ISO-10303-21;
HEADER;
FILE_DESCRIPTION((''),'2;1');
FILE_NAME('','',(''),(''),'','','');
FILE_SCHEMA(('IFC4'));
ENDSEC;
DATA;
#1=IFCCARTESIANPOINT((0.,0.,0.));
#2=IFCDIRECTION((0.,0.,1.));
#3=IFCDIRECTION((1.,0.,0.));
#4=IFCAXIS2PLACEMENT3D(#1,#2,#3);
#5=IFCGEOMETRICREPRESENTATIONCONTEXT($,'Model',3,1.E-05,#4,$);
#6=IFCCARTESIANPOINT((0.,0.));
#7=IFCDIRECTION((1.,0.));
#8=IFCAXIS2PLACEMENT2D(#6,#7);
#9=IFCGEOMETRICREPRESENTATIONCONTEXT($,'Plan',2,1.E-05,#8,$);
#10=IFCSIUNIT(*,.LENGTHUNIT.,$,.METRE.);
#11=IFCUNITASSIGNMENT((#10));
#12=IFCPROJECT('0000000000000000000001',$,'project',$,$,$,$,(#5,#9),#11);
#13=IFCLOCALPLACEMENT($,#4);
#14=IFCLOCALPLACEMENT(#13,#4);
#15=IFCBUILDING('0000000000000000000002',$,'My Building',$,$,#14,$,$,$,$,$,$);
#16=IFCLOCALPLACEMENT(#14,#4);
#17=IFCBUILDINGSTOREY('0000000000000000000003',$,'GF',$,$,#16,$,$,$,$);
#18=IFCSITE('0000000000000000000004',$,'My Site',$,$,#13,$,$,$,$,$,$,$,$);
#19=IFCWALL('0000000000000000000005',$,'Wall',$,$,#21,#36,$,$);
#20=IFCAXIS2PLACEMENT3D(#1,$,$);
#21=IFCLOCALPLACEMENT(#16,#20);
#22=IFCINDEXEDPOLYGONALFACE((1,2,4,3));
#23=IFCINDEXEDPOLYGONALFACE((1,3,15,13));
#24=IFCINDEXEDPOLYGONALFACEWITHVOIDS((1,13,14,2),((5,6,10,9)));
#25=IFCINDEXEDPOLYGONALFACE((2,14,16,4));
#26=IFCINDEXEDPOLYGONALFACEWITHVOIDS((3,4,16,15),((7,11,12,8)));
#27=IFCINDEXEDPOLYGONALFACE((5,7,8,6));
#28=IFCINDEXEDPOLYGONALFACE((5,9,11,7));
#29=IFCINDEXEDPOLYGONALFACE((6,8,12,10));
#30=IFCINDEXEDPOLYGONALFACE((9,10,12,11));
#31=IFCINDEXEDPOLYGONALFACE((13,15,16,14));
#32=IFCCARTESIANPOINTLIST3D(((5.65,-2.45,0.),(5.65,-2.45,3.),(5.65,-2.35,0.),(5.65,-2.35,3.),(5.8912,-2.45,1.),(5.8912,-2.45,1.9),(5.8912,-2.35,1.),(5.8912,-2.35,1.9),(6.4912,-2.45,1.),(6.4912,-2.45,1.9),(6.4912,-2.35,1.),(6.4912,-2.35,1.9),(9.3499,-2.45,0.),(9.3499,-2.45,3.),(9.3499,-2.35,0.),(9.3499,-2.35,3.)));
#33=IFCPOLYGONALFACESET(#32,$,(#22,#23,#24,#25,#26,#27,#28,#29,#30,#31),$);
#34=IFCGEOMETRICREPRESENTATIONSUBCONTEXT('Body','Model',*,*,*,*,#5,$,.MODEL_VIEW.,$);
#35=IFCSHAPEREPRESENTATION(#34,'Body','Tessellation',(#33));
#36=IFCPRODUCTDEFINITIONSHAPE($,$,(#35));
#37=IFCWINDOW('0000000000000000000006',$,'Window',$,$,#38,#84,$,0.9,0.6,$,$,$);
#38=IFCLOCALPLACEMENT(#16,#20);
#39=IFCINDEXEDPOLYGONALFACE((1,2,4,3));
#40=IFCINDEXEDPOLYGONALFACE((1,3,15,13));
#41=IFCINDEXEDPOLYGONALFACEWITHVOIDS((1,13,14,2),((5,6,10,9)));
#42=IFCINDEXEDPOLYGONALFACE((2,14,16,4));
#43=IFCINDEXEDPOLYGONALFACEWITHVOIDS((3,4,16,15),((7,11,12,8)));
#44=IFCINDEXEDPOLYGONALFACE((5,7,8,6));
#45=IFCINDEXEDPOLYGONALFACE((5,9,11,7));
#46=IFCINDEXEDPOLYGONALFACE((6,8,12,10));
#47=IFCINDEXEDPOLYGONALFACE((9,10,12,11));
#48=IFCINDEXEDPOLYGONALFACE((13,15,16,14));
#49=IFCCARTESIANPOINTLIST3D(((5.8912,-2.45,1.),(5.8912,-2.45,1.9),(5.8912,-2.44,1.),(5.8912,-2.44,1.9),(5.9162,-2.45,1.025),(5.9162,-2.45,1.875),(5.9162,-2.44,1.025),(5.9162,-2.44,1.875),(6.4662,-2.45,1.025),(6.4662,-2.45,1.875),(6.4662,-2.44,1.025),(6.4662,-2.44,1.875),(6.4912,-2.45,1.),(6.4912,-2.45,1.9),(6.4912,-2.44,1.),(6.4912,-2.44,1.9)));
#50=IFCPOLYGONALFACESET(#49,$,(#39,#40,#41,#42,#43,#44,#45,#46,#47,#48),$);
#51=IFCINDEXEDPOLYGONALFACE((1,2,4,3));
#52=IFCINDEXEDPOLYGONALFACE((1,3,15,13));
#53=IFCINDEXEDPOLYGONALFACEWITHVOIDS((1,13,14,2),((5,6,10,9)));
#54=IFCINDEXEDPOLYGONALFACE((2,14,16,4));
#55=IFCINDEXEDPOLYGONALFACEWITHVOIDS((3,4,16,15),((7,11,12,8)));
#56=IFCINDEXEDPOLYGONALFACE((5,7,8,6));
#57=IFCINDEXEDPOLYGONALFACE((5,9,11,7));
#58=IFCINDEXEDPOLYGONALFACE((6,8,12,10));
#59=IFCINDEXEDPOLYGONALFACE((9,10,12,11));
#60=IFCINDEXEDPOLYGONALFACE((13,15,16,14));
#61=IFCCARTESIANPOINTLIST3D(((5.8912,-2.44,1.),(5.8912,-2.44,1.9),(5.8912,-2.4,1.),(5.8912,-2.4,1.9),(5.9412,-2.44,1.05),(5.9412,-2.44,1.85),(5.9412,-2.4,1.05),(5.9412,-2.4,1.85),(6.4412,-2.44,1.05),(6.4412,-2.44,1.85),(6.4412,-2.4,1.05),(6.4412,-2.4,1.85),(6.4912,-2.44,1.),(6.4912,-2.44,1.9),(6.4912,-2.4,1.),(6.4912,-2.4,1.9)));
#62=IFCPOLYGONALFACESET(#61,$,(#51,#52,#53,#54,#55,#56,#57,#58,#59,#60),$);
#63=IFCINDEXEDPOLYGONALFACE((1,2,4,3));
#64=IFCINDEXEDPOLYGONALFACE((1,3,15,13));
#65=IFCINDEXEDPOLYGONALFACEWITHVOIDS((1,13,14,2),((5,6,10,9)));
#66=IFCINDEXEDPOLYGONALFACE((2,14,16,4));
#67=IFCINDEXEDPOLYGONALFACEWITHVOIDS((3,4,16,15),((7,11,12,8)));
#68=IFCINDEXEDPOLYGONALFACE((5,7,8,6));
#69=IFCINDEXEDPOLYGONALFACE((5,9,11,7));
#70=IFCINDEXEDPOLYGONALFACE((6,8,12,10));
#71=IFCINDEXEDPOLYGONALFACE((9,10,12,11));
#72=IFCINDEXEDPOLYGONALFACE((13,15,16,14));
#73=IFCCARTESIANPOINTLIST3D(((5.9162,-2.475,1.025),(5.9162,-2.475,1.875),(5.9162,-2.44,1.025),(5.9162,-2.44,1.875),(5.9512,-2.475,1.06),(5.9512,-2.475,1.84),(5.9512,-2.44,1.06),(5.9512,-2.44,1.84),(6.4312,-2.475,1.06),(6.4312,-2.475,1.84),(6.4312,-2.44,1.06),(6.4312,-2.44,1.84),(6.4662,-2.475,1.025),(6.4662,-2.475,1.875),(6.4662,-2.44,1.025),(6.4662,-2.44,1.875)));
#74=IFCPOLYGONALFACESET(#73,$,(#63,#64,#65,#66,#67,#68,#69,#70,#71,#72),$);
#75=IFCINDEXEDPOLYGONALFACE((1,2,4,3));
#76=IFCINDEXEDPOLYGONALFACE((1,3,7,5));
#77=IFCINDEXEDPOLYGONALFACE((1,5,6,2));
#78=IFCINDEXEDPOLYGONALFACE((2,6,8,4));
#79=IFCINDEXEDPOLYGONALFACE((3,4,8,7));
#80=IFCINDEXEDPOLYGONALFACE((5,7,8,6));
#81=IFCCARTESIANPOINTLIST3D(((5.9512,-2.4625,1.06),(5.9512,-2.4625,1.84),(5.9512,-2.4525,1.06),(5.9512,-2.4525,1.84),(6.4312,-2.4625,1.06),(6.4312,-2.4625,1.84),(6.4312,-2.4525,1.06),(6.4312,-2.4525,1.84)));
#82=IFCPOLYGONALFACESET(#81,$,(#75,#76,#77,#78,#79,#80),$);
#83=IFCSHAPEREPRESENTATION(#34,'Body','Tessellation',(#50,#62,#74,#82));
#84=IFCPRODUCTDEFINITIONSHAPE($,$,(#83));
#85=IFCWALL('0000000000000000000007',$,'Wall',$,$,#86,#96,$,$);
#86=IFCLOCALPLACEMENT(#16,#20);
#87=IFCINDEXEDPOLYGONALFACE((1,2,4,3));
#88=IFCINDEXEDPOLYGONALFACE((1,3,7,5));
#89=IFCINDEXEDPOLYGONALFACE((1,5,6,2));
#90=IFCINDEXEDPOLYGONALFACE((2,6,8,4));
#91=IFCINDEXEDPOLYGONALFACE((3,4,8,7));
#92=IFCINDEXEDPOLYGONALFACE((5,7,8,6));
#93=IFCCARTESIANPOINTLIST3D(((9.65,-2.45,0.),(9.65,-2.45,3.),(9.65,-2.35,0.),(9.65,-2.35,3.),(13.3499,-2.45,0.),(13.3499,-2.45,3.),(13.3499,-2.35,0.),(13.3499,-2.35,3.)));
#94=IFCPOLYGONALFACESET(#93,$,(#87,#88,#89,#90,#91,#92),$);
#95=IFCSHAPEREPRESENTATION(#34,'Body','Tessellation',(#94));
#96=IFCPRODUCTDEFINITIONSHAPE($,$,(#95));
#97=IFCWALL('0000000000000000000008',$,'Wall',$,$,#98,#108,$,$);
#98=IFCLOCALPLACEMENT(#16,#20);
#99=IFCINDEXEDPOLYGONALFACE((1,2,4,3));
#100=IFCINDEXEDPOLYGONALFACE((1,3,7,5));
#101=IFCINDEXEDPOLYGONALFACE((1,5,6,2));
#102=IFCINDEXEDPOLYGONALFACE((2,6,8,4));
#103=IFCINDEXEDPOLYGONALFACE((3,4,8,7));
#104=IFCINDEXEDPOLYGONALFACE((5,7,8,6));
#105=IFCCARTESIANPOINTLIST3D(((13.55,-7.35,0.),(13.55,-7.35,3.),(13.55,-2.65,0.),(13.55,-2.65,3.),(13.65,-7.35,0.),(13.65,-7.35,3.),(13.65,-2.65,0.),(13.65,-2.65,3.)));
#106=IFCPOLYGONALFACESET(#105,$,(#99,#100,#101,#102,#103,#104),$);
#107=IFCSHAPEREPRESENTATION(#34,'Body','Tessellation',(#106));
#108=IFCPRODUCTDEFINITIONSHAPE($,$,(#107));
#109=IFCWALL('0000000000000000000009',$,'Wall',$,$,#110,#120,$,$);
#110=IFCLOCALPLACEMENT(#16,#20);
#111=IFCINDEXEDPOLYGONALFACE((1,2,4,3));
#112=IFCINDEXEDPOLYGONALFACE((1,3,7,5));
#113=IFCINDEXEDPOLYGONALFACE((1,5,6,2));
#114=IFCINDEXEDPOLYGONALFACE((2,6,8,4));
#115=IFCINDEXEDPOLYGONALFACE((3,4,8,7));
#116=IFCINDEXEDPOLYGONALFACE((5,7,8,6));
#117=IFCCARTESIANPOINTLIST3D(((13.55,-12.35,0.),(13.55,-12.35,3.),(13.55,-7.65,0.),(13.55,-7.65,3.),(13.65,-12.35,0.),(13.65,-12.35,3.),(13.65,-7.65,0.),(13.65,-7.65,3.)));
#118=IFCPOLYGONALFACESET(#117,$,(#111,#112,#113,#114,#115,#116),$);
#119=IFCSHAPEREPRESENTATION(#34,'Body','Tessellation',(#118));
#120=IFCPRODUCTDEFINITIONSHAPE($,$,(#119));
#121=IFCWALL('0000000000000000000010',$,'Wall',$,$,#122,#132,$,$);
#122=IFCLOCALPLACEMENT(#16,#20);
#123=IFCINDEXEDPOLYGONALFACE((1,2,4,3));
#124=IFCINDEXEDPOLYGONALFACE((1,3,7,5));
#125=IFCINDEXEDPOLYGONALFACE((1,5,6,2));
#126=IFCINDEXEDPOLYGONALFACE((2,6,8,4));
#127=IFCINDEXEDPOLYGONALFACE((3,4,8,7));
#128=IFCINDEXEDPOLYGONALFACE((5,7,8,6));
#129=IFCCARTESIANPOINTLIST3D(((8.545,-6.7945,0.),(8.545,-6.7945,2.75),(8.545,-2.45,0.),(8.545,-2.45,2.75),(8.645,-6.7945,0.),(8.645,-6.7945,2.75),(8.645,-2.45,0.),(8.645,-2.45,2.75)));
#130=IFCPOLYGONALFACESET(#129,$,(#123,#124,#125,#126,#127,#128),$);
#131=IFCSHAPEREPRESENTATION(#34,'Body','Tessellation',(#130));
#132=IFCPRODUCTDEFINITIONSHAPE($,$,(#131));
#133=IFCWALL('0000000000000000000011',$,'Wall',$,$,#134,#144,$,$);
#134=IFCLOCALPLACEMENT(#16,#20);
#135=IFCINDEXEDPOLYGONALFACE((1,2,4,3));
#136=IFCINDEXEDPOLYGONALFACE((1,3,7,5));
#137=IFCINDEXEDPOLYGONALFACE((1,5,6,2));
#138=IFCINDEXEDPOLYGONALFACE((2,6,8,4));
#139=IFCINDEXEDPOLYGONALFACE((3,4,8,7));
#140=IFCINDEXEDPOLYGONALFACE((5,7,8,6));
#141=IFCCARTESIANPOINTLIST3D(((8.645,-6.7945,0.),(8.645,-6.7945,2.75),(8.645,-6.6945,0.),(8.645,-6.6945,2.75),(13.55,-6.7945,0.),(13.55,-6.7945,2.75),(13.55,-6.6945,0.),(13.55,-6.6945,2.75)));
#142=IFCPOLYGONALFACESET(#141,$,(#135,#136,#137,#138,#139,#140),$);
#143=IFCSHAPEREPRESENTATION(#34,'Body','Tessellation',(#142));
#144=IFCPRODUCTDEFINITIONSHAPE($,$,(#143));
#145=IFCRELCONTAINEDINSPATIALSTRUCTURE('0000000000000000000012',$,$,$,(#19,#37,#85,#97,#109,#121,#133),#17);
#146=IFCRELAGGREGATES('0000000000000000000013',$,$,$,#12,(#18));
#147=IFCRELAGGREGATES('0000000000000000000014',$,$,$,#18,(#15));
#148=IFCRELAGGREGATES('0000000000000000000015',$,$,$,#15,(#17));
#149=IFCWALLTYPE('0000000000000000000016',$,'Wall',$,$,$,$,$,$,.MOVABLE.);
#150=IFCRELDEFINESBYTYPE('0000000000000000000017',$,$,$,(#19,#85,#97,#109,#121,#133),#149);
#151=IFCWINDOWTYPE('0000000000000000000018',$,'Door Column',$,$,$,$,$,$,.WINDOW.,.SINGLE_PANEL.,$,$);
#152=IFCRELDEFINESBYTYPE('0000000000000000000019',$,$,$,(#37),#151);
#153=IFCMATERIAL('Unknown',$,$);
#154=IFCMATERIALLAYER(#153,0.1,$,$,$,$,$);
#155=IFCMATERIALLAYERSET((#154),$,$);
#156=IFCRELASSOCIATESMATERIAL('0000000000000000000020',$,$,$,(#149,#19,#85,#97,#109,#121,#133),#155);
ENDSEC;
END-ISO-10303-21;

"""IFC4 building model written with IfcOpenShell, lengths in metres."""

from ifc_helpers import new_model, entity, si_unit, frame, origin_with_axes, origin_2d_with_axis, place, context, subcontext, project, spatial, line, indexed_curve, outline, extrude, shape, source, transform, mapped, material, layer, layer_set, layer_usage, type_object, type_shapes, element, fill, save


model = new_model("IFC4")

# Units and contexts
model_context = context("Model", 3, precision=1e-05, world=origin_with_axes())
plan_context = context("Plan", 2, precision=1e-05, world=origin_2d_with_axis())
body_context_1 = subcontext(model_context, "Body", "Model", "MODEL_VIEW")
body_context_2 = subcontext(plan_context, "Body", "Plan", "PLAN_VIEW")
ifc_project = project(units=[si_unit("LENGTHUNIT", "METRE")], contexts=[model_context, plan_context])

# Site, building, storey
site_placement = place(None, origin_with_axes())
site = spatial("IfcSite", under=ifc_project, at=site_placement, Name="My Site")
building_placement = place(site_placement, origin_with_axes())
building = spatial("IfcBuilding", under=site, at=building_placement, Name="My Building")
storey_placement = place(building_placement, origin_with_axes())
storey = spatial("IfcBuildingStorey", under=building, at=storey_placement, Name="GF")

# Shared definitions
ifc_material_1 = material(Name="Unknown")

# Wall, opening, window
ifc_layer_1 = layer(ifc_material_1, 0.1)
ifc_layer_set_1 = layer_set([ifc_layer_1])
ifc_layer_usage_1 = layer_usage(ifc_layer_set_1, "AXIS2", "POSITIVE", 0.0)
wall_type_1 = type_object("IfcWallType", Name="Wall", PredefinedType="MOVABLE", material=ifc_layer_set_1)
wall_1_placement = place(storey_placement, frame((5.65, -2.45, 0.0), z_axis=(0.0, 0.0, 1.0), x_axis=(1.0, 0.0, 0.0)))
wall_1 = element("IfcWall", 1, at=wall_1_placement, inside=storey, type_object=wall_type_1, material=ifc_layer_usage_1, Name="Wall", context=body_context_1, shape_type="SweptSolid", body=[
    extrude(outline(indexed_curve([(0.0, 0.0), (0.0, 0.1), (3.6999, 0.1), (3.6999, 0.0)], segments=[line(1, 2, 3, 4, 1)])), origin_with_axes(), (0.0, 0.0, 1.0), 3.0),
])
shared_shape_1 = source(origin_with_axes(), body_context_1, "Body", "SweptSolid", [
    extrude(outline(indexed_curve([(0.0, 0.0), (0.6, 0.0), (0.6, 0.9), (0.0, 0.9)], segments=[line(1, 2, 3, 4, 1)])), frame((0.0, -0.6, 0.0), z_axis=(0.0, -1.0, 0.0), x_axis=(1.0, 0.0, 0.0)), (0.0, 0.0, -1.0), 1.2),
])
opening_1_placement = place(wall_1_placement, frame((0.8412, 0.1, 1.0), z_axis=(0.0, 0.0, 1.0), x_axis=(-1.0, 0.0, 0.0)))
opening_1 = element("IfcOpeningElement", 2, at=opening_1_placement, cuts=wall_1, PredefinedType="OPENING", context=body_context_1, shape_type="MappedRepresentation", body=[
    mapped(shared_shape_1, transform((0.0, 0.0, 0.0), x_axis=(1.0, 0.0, 0.0), y_axis=(0.0, 1.0, 0.0), z_axis=(0.0, 0.0, 1.0), scale=1.0)),
])
window_type = type_object("IfcWindowType", Name="Door Column", PartitioningType="SINGLE_PANEL", PredefinedType="WINDOW")
shared_shape_2 = source(origin_with_axes(), body_context_1, "Body", "SweptSolid", [
    extrude(outline(indexed_curve([(0.0, 0.0), (0.6, 0.0), (0.6, 0.9), (0.0, 0.9)], segments=[line(1, 2, 3, 4, 1)]), holes=[indexed_curve([(0.025, 0.025), (0.575, 0.025), (0.575, 0.875), (0.025, 0.875)], segments=[line(1, 2, 3, 4, 1)])]), frame((0.0, 0.09, 0.0), z_axis=(0.0, -1.0, 0.0), x_axis=(1.0, 0.0, 0.0)), (0.0, 0.0, -1.0), 0.01),
    extrude(outline(indexed_curve([(0.0, 0.0), (0.6, 0.0), (0.6, 0.9), (0.0, 0.9)], segments=[line(1, 2, 3, 4, 1)]), holes=[indexed_curve([(0.05, 0.05), (0.55, 0.05), (0.55, 0.85), (0.05, 0.85)], segments=[line(1, 2, 3, 4, 1)])]), frame((0.0, 0.05, 0.0), z_axis=(0.0, -1.0, 0.0), x_axis=(1.0, 0.0, 0.0)), (0.0, 0.0, -1.0), 0.04),
    extrude(outline(indexed_curve([(0.0, 0.0), (0.55, 0.0), (0.55, 0.85), (0.0, 0.85)], segments=[line(1, 2, 3, 4, 1)]), holes=[indexed_curve([(0.035, 0.035), (0.515, 0.035), (0.515, 0.815), (0.035, 0.815)], segments=[line(1, 2, 3, 4, 1)])]), frame((0.025, 0.09, 0.025), z_axis=(0.0, -1.0, 0.0), x_axis=(1.0, 0.0, 0.0)), (0.0, 0.0, -1.0), 0.035),
    extrude(outline(indexed_curve([(0.035, 0.035), (0.515, 0.035), (0.515, 0.815), (0.035, 0.815)], segments=[line(1, 2, 3, 4, 1)])), frame((0.025, 0.1025, 0.025), z_axis=(0.0, -1.0, 0.0), x_axis=(1.0, 0.0, 0.0)), (0.0, 0.0, -1.0), 0.01),
])
shared_shape_3 = source(origin_with_axes(), body_context_2, "Body", "Curve2D", [
    entity("IfcIndexedPolyCurve", entity("IfcCartesianPointList2D", [[0.05, 0.05], [0.55, 0.05]])),
    entity("IfcIndexedPolyCurve", entity("IfcCartesianPointList2D", [[0.0, 0.1], [0.025, 0.1], [0.025, 0.09], [0.05, 0.09], [0.05, 0.05], [0.0, 0.05]]), [entity("IfcLineIndex", [1, 2, 3, 4, 5, 6, 1])]),
    entity("IfcIndexedPolyCurve", entity("IfcCartesianPointList2D", [[0.6, 0.1], [0.575, 0.1], [0.575, 0.09], [0.55, 0.09], [0.55, 0.05], [0.6, 0.05]]), [entity("IfcLineIndex", [1, 2, 3, 4, 5, 6, 1])]),
    entity("IfcIndexedPolyCurve", entity("IfcCartesianPointList2D", [[0.025, 0.09], [0.06, 0.09], [0.06, 0.125], [0.025, 0.125]]), [entity("IfcLineIndex", [1, 2, 3, 4, 1])]),
    entity("IfcIndexedPolyCurve", entity("IfcCartesianPointList2D", [[0.575, 0.09], [0.54, 0.09], [0.54, 0.125], [0.575, 0.125]]), [entity("IfcLineIndex", [1, 2, 3, 4, 1])]),
    entity("IfcIndexedPolyCurve", entity("IfcCartesianPointList2D", [[0.06, 0.09], [0.54, 0.09]])),
    entity("IfcIndexedPolyCurve", entity("IfcCartesianPointList2D", [[0.06, 0.125], [0.54, 0.125]])),
    entity("IfcIndexedPolyCurve", entity("IfcCartesianPointList2D", [[0.06, 0.1075], [0.54, 0.1075]])),
])
type_shapes(window_type, [shared_shape_2, shared_shape_3])
window_placement = place(opening_1_placement, frame((0.0, 0.0, 0.0), z_axis=(0.0, 0.0, 1.0), x_axis=(1.0, 0.0, 0.0)))
window = element("IfcWindow", 3, at=window_placement, inside=storey, type_object=window_type, Name="Window", OverallHeight=0.9, OverallWidth=0.6, shapes=[
    shape(body_context_1, "Body", "MappedRepresentation", [mapped(shared_shape_2, transform((0.0, 0.0, 0.0), x_axis=(1.0, 0.0, 0.0), y_axis=(0.0, 1.0, 0.0), z_axis=(0.0, 0.0, 1.0), scale=1.0))]),
    shape(body_context_2, "Body", "MappedRepresentation", [mapped(shared_shape_3, transform((0.0, 0.0, 0.0), x_axis=(1.0, 0.0, 0.0), y_axis=(0.0, 1.0, 0.0), z_axis=(0.0, 0.0, 1.0), scale=1.0))]),
])
fill(opening_1, window)

# Walls
ifc_layer_usage_2 = layer_usage(ifc_layer_set_1, "AXIS2", "POSITIVE", 0.0)
wall_2_placement = place(storey_placement, frame((9.65, -2.45, 0.0), z_axis=(0.0, 0.0, 1.0), x_axis=(1.0, 0.0, 0.0)))
element("IfcWall", 4, at=wall_2_placement, inside=storey, type_object=wall_type_1, material=ifc_layer_usage_2, Name="Wall", context=body_context_1, shape_type="SweptSolid", body=[
    extrude(outline(indexed_curve([(0.0, 0.0), (0.0, 0.1), (3.6999, 0.1), (3.6999, 0.0)], segments=[line(1, 2, 3, 4, 1)])), origin_with_axes(), (0.0, 0.0, 1.0), 3.0),
])
ifc_layer_usage_3 = layer_usage(ifc_layer_set_1, "AXIS2", "POSITIVE", 0.0)
wall_3_placement = place(storey_placement, frame((13.55, -2.65, 0.0), z_axis=(0.0, 0.0, 1.0), x_axis=(0.0, -1.0, 0.0)))
element("IfcWall", 5, at=wall_3_placement, inside=storey, type_object=wall_type_1, material=ifc_layer_usage_3, Name="Wall", context=body_context_1, shape_type="SweptSolid", body=[
    extrude(outline(indexed_curve([(0.0, 0.0), (0.0, 0.1), (4.7, 0.1), (4.7, 0.0)], segments=[line(1, 2, 3, 4, 1)])), origin_with_axes(), (0.0, 0.0, 1.0), 3.0),
])
ifc_layer_usage_4 = layer_usage(ifc_layer_set_1, "AXIS2", "POSITIVE", 0.0)
wall_4_placement = place(storey_placement, frame((13.55, -7.65, 0.0), z_axis=(0.0, 0.0, 1.0), x_axis=(0.0, -1.0, 0.0)))
element("IfcWall", 6, at=wall_4_placement, inside=storey, type_object=wall_type_1, material=ifc_layer_usage_4, Name="Wall", context=body_context_1, shape_type="SweptSolid", body=[
    extrude(outline(indexed_curve([(0.0, 0.0), (0.0, 0.1), (4.7, 0.1), (4.7, 0.0)], segments=[line(1, 2, 3, 4, 1)])), origin_with_axes(), (0.0, 0.0, 1.0), 3.0),
])
ifc_layer_usage_5 = layer_usage(ifc_layer_set_1, "AXIS2", "POSITIVE", 0.0)
wall_5_placement = place(storey_placement, frame((8.545, -2.45, 0.0), z_axis=(0.0, 0.0, 1.0), x_axis=(0.0, -1.0, 0.0)))
element("IfcWall", 7, at=wall_5_placement, inside=storey, type_object=wall_type_1, material=ifc_layer_usage_5, Name="Wall", context=body_context_1, shape_type="SweptSolid", body=[
    extrude(outline(indexed_curve([(0.0, 0.0), (0.0, 0.1), (4.3445, 0.1), (4.3445, 0.0)], segments=[line(1, 2, 3, 4, 1)])), origin_with_axes(), (0.0, 0.0, 1.0), 2.75),
])
ifc_layer_usage_6 = layer_usage(ifc_layer_set_1, "AXIS2", "POSITIVE", 0.0)
wall_6_placement = place(storey_placement, frame((8.645, -6.7945, 0.0), z_axis=(0.0, 0.0, 1.0), x_axis=(1.0, 0.0, 0.0)))
element("IfcWall", 8, at=wall_6_placement, inside=storey, type_object=wall_type_1, material=ifc_layer_usage_6, Name="Wall", context=body_context_1, shape_type="SweptSolid", body=[
    extrude(outline(indexed_curve([(0.0, 0.0), (0.0, 0.1), (4.905, 0.1), (4.905, 0.0)], segments=[line(1, 2, 3, 4, 1)])), origin_with_axes(), (0.0, 0.0, 1.0), 2.75),
])

save(model, "model.ifc")
